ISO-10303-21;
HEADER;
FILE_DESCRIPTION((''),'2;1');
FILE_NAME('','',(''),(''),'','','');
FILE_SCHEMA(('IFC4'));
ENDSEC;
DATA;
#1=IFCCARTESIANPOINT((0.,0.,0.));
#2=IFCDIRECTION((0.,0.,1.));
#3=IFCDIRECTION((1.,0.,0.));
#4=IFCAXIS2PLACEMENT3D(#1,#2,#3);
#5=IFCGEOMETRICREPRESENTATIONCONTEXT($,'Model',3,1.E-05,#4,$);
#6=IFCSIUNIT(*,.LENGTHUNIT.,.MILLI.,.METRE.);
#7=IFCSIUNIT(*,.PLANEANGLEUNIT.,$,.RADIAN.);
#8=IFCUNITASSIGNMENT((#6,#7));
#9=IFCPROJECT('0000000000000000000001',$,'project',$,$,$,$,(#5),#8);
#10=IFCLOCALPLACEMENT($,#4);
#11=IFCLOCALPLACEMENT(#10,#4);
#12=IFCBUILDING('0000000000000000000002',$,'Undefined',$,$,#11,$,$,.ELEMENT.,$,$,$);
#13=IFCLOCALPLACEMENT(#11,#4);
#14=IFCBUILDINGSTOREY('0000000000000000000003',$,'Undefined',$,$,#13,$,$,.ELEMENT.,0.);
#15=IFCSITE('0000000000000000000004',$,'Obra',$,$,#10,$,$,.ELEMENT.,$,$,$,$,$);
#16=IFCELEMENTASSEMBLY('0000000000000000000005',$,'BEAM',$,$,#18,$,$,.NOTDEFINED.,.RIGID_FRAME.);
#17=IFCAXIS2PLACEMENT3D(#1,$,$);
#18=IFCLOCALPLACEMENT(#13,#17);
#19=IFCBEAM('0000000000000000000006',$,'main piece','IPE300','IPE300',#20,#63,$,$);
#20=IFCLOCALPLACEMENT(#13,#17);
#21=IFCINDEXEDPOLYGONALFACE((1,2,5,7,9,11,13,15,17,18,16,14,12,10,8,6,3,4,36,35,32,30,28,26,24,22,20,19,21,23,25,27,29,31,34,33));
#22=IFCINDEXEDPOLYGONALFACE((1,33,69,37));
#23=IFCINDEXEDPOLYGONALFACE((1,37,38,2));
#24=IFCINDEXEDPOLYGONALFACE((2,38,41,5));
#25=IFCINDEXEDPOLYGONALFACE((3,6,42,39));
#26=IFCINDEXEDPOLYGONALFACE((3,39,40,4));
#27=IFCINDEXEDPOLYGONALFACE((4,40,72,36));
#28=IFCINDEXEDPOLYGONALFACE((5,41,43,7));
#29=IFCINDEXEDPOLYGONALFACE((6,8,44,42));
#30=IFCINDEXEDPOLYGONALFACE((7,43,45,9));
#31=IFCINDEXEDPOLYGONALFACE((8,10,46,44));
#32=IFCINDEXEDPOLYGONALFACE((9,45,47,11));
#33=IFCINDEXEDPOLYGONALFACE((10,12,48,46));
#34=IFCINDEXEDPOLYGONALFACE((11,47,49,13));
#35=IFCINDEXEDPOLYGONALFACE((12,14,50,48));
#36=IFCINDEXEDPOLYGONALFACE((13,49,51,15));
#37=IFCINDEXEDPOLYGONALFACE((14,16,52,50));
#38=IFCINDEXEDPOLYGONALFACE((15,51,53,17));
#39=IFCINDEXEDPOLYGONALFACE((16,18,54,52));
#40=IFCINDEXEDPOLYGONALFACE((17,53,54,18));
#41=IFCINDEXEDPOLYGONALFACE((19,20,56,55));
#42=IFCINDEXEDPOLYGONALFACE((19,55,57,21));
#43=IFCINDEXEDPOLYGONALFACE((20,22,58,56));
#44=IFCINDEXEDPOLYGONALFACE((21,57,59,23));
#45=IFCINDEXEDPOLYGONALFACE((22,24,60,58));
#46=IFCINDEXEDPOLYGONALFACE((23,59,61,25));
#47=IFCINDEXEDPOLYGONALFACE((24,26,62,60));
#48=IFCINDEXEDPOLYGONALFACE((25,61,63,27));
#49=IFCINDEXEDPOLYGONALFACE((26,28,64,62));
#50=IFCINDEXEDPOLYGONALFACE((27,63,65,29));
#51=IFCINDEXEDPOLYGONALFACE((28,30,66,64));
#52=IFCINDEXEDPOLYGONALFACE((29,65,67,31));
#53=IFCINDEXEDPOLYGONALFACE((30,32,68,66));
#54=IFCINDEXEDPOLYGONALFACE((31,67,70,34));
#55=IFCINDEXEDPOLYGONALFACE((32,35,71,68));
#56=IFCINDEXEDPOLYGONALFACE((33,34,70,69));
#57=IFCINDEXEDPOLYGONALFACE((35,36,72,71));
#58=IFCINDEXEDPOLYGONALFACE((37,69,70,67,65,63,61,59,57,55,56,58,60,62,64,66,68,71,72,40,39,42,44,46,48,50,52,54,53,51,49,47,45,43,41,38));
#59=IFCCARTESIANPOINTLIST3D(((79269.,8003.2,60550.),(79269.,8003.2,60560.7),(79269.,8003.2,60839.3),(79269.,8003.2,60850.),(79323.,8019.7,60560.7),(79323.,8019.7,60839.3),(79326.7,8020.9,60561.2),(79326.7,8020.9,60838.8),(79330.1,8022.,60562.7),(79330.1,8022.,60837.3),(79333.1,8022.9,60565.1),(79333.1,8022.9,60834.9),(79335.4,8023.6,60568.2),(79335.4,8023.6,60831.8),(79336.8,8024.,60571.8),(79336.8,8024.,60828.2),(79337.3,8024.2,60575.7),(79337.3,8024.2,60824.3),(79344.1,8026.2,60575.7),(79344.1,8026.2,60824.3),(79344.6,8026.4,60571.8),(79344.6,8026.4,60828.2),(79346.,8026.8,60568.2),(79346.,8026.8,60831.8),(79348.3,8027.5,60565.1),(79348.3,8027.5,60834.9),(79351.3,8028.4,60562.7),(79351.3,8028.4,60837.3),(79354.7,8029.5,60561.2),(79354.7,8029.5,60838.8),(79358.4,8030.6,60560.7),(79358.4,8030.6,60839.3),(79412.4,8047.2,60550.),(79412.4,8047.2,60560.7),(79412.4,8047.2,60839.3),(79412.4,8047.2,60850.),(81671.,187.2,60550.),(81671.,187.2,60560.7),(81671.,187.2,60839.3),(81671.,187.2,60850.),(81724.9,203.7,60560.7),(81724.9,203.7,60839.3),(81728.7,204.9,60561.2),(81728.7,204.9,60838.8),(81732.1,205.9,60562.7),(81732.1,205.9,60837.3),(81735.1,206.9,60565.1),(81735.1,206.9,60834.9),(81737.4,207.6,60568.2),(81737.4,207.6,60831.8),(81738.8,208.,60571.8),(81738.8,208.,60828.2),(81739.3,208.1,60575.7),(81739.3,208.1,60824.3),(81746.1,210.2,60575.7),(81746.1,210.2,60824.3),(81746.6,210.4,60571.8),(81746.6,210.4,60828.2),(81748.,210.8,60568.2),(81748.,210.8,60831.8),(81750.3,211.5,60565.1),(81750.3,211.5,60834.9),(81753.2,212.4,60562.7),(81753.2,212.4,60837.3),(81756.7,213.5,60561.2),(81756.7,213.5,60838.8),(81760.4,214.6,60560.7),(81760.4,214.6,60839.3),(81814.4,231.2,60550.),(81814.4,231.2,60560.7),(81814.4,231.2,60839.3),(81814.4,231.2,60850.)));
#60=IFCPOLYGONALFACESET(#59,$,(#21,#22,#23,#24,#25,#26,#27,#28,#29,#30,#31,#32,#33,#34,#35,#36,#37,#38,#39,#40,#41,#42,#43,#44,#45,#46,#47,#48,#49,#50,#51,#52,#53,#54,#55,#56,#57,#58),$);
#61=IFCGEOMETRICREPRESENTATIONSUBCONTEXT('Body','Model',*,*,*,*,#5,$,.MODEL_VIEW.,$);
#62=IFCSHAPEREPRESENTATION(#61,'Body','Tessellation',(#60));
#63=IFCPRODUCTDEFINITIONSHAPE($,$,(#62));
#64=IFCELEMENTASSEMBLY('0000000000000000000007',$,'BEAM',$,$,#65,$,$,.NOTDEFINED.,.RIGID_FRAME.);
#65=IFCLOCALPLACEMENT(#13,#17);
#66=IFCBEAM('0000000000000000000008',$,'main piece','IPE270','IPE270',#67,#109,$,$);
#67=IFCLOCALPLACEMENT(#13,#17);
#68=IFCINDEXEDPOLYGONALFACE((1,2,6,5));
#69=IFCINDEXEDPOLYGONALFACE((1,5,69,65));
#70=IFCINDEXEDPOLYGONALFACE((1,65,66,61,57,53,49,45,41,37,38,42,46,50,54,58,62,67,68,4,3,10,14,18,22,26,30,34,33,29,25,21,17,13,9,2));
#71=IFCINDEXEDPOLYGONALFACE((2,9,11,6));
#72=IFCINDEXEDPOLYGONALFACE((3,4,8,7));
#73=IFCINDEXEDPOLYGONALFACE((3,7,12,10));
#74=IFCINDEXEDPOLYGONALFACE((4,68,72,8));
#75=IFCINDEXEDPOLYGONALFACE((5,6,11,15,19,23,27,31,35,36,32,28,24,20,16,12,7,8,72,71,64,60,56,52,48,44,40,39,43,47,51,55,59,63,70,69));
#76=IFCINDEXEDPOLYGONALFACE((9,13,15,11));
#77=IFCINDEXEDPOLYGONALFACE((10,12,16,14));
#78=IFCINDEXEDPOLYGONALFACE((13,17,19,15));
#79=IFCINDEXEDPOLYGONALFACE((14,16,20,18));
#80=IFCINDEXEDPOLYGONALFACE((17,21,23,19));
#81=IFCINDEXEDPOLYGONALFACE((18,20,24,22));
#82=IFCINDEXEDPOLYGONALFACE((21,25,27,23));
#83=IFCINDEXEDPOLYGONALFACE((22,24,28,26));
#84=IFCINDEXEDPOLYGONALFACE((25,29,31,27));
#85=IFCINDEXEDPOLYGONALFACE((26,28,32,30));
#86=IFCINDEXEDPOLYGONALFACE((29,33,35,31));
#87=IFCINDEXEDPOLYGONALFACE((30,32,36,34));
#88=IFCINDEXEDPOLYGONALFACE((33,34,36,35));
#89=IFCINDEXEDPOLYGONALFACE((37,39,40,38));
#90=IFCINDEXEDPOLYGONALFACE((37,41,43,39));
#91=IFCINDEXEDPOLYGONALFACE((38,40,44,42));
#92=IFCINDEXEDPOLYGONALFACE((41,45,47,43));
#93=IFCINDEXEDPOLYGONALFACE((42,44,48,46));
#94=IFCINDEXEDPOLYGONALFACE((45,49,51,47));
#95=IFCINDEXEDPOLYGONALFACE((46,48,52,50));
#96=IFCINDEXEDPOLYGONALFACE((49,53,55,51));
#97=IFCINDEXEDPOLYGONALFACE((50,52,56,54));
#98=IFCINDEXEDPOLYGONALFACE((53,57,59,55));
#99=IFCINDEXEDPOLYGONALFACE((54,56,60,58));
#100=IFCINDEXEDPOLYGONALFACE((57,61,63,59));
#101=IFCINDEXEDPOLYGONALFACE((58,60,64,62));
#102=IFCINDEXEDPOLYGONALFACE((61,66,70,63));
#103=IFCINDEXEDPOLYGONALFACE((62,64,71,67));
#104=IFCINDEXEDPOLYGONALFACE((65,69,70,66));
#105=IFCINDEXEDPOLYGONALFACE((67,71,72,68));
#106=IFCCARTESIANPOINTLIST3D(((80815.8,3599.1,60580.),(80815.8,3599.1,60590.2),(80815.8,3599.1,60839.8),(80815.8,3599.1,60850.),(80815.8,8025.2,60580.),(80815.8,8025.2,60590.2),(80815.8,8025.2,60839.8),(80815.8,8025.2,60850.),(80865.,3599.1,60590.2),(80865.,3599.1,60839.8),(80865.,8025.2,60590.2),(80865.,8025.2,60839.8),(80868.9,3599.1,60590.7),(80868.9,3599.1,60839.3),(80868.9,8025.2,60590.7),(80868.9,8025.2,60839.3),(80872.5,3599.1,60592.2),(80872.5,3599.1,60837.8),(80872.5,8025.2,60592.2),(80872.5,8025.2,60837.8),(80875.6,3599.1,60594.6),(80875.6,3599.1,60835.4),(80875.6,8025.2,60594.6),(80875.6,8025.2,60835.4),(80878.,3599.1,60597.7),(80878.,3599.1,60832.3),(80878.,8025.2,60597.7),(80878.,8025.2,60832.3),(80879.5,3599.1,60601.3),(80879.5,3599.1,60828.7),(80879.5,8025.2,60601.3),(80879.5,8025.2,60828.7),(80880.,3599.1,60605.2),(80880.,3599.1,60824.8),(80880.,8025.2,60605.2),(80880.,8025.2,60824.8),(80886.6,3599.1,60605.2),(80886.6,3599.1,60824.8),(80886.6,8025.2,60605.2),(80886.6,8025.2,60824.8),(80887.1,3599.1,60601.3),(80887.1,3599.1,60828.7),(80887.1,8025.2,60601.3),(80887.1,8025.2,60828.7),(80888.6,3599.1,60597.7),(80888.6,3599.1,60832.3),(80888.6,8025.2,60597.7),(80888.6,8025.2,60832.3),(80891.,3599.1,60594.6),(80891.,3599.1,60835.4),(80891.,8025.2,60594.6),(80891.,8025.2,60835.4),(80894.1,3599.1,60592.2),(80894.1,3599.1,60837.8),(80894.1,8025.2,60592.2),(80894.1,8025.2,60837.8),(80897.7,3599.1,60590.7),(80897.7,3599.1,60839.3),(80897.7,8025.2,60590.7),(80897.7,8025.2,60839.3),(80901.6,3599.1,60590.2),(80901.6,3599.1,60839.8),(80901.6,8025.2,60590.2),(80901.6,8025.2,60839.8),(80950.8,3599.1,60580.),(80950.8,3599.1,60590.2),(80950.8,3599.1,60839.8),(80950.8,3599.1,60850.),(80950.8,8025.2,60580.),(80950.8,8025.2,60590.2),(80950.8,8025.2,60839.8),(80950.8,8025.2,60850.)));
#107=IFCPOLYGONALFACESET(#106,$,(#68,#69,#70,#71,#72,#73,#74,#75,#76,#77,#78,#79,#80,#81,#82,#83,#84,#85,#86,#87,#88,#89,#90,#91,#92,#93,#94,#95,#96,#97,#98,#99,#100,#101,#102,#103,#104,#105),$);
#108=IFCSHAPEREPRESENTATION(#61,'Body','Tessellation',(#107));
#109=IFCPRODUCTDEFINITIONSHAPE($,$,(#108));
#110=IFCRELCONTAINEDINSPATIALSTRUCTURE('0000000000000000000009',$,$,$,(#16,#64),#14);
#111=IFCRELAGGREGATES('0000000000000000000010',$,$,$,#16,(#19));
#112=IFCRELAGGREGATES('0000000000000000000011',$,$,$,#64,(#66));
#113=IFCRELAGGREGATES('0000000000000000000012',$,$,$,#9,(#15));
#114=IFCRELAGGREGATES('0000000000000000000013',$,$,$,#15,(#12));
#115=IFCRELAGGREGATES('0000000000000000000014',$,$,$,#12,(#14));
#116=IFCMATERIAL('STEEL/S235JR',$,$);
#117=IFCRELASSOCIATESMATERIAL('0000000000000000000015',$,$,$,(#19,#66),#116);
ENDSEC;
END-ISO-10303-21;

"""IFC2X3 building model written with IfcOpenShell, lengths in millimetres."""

from ifc_helpers import new_model, si_unit, frame, origin_with_axes, origin_2d_with_axis, place, context, subcontext, project, spatial, i_section, extrude, material, element, aggregate, save


model = new_model("IFC2X3")

# Units and contexts
model_context = context("Model", 3, precision=1e-05, world=origin_with_axes())
body_context = subcontext(model_context, "Body", "Model", "MODEL_VIEW")
ifc_project = project(units=[si_unit("LENGTHUNIT", "METRE", prefix="MILLI"), si_unit("PLANEANGLEUNIT", "RADIAN")], contexts=[model_context])

# Site, building, storey
site_placement = place(None, origin_with_axes())
site = spatial("IfcSite", under=ifc_project, at=site_placement, Name="Obra", CompositionType="ELEMENT")
building_placement = place(site_placement, origin_with_axes())
building = spatial("IfcBuilding", under=site, at=building_placement, Name="Undefined", CompositionType="ELEMENT")
storey_placement = place(building_placement, origin_with_axes())
storey = spatial("IfcBuildingStorey", under=building, at=storey_placement, Name="Undefined", CompositionType="ELEMENT", Elevation=0.0)

# Shared definitions
ifc_material_1 = material(Name="STEEL/S235JR")

# Element assemblies, beams
assembly_1_placement = place(storey_placement, origin_with_axes())
assembly_1 = element("IfcElementAssembly", 1, at=assembly_1_placement, inside=storey, Name="BEAM", AssemblyPlace="NOTDEFINED", PredefinedType="RIGID_FRAME")
beam_1_placement = place(assembly_1_placement, frame((79340.7, 8025.2, 60700.0), z_axis=(0.0, 0.0, 1.0), x_axis=(0.293756, -0.955881, 0.0)))
beam_1 = element("IfcBeam", 2, at=beam_1_placement, material=ifc_material_1, Name="main piece", Description="IPE300", ObjectType="IPE300", context=body_context, shape_type="SweptSolid", body=[
    extrude(i_section(OverallWidth=150.0, OverallDepth=300.0, WebThickness=7.1, FlangeThickness=10.7, FilletRadius=15.0, at=origin_2d_with_axis()), frame((8176.8, 0.0, 0.0), z_axis=(-1.0, 0.0, 0.0), x_axis=(0.0, -1.0, 0.0)), (0.0, 0.0, 1.0), 8176.8),
])
aggregate(assembly_1, [beam_1])
assembly_2_placement = place(storey_placement, origin_with_axes())
assembly_2 = element("IfcElementAssembly", 3, at=assembly_2_placement, inside=storey, Name="BEAM", AssemblyPlace="NOTDEFINED", PredefinedType="RIGID_FRAME")
beam_2_placement = place(assembly_2_placement, frame((80883.3, 3599.1, 60715.0), z_axis=(0.0, 0.0, 1.0), x_axis=(0.0, 1.0, 0.0)))
beam_2 = element("IfcBeam", 4, at=beam_2_placement, material=ifc_material_1, Name="main piece", Description="IPE270", ObjectType="IPE270", context=body_context, shape_type="SweptSolid", body=[
    extrude(i_section(OverallWidth=135.0, OverallDepth=270.0, WebThickness=6.6, FlangeThickness=10.2, FilletRadius=15.0, at=origin_2d_with_axis()), frame((4426.1, 0.0, 0.0), z_axis=(-1.0, 0.0, 0.0), x_axis=(0.0, -1.0, 0.0)), (0.0, 0.0, 1.0), 4426.1),
])
aggregate(assembly_2, [beam_2])

save(model, "model.ifc")
